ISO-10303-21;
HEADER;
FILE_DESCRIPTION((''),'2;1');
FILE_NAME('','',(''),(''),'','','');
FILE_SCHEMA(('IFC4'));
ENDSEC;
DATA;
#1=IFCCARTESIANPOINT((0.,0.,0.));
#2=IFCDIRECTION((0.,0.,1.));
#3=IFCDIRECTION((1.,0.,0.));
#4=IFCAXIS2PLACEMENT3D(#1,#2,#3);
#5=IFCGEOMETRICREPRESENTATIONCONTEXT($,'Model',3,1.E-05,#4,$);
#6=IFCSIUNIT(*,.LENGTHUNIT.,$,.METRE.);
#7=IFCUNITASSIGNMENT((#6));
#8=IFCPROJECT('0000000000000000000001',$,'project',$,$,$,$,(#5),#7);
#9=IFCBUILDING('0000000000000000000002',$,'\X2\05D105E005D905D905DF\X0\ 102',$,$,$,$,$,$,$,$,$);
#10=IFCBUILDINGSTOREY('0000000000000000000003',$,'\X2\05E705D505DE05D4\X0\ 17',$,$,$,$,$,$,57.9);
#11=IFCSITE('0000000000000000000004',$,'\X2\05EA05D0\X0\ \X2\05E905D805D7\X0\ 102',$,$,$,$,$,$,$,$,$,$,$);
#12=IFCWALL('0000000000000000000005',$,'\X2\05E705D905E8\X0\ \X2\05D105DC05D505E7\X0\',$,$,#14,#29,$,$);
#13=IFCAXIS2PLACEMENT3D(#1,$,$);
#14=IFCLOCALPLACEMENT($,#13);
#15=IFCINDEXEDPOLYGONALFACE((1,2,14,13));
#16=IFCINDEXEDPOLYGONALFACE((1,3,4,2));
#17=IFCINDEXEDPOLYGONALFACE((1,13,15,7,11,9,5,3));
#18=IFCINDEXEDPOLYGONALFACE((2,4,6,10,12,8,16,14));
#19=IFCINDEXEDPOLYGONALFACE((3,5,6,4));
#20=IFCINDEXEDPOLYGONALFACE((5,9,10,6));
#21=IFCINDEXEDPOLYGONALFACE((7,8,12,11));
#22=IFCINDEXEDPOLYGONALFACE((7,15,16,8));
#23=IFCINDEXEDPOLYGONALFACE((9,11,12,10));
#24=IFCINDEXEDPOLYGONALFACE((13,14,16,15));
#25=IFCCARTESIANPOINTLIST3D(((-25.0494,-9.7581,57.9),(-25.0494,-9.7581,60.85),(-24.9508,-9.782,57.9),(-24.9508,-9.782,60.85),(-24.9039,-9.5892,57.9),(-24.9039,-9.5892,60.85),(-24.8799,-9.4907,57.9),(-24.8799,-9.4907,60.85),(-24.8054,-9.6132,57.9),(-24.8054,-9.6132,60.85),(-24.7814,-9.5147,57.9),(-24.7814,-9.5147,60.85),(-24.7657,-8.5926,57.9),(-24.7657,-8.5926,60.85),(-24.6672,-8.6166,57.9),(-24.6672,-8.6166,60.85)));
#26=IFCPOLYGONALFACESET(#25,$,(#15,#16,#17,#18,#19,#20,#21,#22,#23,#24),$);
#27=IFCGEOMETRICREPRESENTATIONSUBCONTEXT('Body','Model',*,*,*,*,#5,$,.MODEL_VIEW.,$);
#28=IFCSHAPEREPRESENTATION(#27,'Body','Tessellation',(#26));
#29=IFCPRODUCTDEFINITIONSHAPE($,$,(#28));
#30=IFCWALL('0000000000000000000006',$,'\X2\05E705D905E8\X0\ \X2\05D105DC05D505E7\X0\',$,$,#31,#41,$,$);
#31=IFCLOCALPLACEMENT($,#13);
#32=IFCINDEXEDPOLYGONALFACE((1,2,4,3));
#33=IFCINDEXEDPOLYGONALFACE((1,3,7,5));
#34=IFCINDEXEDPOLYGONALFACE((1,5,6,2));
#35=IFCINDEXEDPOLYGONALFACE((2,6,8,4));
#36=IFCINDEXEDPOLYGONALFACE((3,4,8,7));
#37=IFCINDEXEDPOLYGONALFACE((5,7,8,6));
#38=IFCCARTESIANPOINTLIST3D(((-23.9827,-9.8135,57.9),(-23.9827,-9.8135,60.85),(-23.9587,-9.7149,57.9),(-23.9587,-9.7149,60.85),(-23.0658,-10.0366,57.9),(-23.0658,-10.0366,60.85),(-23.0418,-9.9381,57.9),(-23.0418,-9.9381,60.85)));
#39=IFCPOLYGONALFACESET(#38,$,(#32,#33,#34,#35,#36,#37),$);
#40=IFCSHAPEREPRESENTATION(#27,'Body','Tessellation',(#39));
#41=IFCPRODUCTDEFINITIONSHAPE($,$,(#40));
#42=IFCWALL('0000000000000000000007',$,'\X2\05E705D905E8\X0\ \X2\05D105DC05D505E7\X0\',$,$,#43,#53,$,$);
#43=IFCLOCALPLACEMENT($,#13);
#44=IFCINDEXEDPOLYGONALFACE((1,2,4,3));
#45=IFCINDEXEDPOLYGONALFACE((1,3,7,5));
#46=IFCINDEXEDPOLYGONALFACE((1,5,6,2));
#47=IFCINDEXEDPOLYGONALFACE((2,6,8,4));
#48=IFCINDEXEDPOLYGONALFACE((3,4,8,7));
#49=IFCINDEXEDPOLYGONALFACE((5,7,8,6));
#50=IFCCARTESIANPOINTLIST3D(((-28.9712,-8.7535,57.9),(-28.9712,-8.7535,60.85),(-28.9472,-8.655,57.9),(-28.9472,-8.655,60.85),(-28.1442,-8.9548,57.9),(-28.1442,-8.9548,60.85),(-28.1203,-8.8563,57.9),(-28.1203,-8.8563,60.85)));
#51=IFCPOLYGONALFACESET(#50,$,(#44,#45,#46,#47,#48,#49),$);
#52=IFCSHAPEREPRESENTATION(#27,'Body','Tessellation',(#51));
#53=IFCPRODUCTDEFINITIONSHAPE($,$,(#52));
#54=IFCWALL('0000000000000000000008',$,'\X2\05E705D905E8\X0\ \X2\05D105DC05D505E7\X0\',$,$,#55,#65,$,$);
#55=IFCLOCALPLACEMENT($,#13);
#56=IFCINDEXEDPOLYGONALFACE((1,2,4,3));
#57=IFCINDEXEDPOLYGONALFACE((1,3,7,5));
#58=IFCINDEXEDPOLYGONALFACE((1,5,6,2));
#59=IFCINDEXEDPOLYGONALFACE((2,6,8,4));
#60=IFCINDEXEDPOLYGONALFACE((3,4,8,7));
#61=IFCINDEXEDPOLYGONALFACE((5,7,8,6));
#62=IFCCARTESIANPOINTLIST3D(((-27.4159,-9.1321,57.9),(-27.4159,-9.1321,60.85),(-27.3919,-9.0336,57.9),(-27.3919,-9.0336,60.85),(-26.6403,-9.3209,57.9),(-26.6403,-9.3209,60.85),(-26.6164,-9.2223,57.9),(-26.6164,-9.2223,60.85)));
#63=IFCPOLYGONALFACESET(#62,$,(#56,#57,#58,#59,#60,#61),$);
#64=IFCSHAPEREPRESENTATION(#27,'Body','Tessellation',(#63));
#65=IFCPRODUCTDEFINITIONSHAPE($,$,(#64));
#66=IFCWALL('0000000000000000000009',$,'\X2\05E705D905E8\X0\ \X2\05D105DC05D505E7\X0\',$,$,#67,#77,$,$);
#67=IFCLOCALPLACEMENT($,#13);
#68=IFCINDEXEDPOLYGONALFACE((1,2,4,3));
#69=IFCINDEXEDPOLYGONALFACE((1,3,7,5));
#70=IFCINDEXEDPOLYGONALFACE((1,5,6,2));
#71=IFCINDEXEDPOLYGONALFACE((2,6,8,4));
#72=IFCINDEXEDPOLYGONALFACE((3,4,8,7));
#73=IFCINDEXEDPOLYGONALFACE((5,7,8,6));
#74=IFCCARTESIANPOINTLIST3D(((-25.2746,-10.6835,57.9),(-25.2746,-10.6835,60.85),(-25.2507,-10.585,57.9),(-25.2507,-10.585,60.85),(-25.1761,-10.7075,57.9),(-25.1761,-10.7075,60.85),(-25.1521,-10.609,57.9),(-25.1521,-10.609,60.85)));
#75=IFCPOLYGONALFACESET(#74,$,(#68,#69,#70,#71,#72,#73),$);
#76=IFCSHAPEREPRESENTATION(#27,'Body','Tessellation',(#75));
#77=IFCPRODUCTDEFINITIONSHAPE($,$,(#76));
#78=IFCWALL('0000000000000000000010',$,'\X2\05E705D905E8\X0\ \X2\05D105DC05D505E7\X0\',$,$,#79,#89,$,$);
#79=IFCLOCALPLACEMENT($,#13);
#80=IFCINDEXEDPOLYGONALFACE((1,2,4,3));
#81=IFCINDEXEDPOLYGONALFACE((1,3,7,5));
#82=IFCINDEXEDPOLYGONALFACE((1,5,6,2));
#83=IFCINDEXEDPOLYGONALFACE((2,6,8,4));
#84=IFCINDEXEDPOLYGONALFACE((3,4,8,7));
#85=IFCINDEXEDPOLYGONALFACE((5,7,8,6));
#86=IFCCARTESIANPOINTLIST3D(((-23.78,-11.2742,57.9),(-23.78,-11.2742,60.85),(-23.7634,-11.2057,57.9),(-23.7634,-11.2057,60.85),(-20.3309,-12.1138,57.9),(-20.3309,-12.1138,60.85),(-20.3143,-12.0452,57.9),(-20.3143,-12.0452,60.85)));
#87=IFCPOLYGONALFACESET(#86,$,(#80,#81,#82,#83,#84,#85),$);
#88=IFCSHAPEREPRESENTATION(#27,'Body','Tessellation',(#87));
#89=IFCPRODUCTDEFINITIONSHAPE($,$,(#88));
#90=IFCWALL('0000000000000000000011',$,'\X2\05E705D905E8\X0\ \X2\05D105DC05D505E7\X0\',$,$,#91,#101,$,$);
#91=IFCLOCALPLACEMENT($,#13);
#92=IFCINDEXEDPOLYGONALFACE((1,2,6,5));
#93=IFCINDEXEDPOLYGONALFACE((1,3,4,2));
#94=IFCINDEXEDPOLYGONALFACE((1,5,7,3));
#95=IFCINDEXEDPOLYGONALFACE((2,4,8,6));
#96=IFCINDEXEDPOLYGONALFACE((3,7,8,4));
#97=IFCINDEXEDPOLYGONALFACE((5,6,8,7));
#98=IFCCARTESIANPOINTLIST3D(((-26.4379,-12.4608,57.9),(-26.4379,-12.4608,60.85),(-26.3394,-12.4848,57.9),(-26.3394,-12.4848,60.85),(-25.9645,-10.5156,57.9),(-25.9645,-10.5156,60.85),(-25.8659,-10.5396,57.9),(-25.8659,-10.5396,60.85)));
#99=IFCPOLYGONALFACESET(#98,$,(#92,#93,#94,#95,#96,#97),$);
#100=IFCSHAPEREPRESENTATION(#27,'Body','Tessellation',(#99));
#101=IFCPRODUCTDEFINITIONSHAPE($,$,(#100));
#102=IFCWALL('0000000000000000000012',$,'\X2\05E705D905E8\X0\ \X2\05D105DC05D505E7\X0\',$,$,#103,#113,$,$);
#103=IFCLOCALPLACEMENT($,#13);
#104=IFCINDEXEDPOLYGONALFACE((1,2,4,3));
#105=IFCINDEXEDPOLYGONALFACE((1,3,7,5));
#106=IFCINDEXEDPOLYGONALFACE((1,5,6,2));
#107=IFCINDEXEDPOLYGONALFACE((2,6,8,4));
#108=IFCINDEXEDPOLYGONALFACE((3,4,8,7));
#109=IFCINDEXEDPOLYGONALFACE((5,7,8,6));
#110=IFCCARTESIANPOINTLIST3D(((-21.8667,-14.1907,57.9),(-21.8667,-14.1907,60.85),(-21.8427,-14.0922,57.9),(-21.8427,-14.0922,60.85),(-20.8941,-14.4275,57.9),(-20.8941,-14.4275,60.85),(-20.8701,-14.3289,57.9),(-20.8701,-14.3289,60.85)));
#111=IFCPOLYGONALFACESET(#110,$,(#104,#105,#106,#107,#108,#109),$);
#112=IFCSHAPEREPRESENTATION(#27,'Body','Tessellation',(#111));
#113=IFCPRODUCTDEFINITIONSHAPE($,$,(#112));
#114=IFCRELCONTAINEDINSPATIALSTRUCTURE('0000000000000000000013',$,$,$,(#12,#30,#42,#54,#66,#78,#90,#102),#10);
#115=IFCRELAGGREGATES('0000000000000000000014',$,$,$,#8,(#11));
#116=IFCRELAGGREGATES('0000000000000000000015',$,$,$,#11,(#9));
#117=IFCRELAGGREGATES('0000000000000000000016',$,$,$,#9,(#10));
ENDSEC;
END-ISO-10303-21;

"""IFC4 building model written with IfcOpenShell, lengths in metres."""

from ifc_helpers import new_model, si_unit, frame, origin_with_axes, context, subcontext, project, spatial, polyline, outline, extrude, element, save


model = new_model("IFC4")

# Units and contexts
model_context = context("Model", 3, precision=1e-05, world=origin_with_axes())
body_context = subcontext(model_context, "Body", "Model", "MODEL_VIEW")
ifc_project = project(units=[si_unit("LENGTHUNIT", "METRE")], contexts=[model_context])

# Site, building, storey
site = spatial("IfcSite", under=ifc_project, Name="תא שטח 102")
building = spatial("IfcBuilding", under=site, Name="בניין 102")
storey = spatial("IfcBuildingStorey", under=building, Name="קומה 17", Elevation=57.9)

# Walls
element("IfcWall", 1, inside=storey, Name="קיר בלוק", context=body_context, shape_type="SweptSolid", body=[
    extrude(outline(polyline([(-24.8054, -9.6132), (-24.7814, -9.5147), (-24.8799, -9.4907), (-24.6672, -8.6166), (-24.7657, -8.5926), (-25.0494, -9.7581), (-24.9508, -9.782), (-24.9039, -9.5892), (-24.8054, -9.6132)])), frame((0.0, 0.0, 57.9)), (0.0, 0.0, 1.0), 2.95),
])
element("IfcWall", 2, inside=storey, Name="קיר בלוק", context=body_context, shape_type="SweptSolid", body=[
    extrude(outline(polyline([(-23.9587, -9.7149), (-23.9827, -9.8135), (-23.0658, -10.0366), (-23.0418, -9.9381), (-23.9587, -9.7149)])), frame((0.0, 0.0, 57.9)), (0.0, 0.0, 1.0), 2.95),
])
element("IfcWall", 3, inside=storey, Name="קיר בלוק", context=body_context, shape_type="SweptSolid", body=[
    extrude(outline(polyline([(-28.9712, -8.7535), (-28.1442, -8.9548), (-28.1203, -8.8563), (-28.9472, -8.655), (-28.9712, -8.7535)])), frame((0.0, 0.0, 57.9)), (0.0, 0.0, 1.0), 2.95),
])
element("IfcWall", 4, inside=storey, Name="קיר בלוק", context=body_context, shape_type="SweptSolid", body=[
    extrude(outline(polyline([(-27.3919, -9.0336), (-27.4159, -9.1321), (-26.6403, -9.3209), (-26.6164, -9.2223), (-27.3919, -9.0336)])), frame((0.0, 0.0, 57.9)), (0.0, 0.0, 1.0), 2.95),
])
element("IfcWall", 5, inside=storey, Name="קיר בלוק", context=body_context, shape_type="SweptSolid", body=[
    extrude(outline(polyline([(-25.1521, -10.609), (-25.2507, -10.585), (-25.2746, -10.6835), (-25.1761, -10.7075), (-25.1521, -10.609)])), frame((0.0, 0.0, 57.9)), (0.0, 0.0, 1.0), 2.95),
])
element("IfcWall", 6, inside=storey, Name="קיר בלוק", context=body_context, shape_type="SweptSolid", body=[
    extrude(outline(polyline([(-23.7634, -11.2057), (-23.78, -11.2742), (-20.3309, -12.1138), (-20.3143, -12.0452), (-23.7634, -11.2057)])), frame((0.0, 0.0, 57.9)), (0.0, 0.0, 1.0), 2.95),
])
element("IfcWall", 7, inside=storey, Name="קיר בלוק", context=body_context, shape_type="SweptSolid", body=[
    extrude(outline(polyline([(-26.4379, -12.4608), (-26.3394, -12.4848), (-25.8659, -10.5396), (-25.9645, -10.5156), (-26.4379, -12.4608)])), frame((0.0, 0.0, 57.9)), (0.0, 0.0, 1.0), 2.95),
])
element("IfcWall", 8, inside=storey, Name="קיר בלוק", context=body_context, shape_type="SweptSolid", body=[
    extrude(outline(polyline([(-20.8701, -14.3289), (-21.8427, -14.0922), (-21.8667, -14.1907), (-20.8941, -14.4275), (-20.8701, -14.3289)])), frame((0.0, 0.0, 57.9)), (0.0, 0.0, 1.0), 2.95),
])

save(model, "model.ifc")
